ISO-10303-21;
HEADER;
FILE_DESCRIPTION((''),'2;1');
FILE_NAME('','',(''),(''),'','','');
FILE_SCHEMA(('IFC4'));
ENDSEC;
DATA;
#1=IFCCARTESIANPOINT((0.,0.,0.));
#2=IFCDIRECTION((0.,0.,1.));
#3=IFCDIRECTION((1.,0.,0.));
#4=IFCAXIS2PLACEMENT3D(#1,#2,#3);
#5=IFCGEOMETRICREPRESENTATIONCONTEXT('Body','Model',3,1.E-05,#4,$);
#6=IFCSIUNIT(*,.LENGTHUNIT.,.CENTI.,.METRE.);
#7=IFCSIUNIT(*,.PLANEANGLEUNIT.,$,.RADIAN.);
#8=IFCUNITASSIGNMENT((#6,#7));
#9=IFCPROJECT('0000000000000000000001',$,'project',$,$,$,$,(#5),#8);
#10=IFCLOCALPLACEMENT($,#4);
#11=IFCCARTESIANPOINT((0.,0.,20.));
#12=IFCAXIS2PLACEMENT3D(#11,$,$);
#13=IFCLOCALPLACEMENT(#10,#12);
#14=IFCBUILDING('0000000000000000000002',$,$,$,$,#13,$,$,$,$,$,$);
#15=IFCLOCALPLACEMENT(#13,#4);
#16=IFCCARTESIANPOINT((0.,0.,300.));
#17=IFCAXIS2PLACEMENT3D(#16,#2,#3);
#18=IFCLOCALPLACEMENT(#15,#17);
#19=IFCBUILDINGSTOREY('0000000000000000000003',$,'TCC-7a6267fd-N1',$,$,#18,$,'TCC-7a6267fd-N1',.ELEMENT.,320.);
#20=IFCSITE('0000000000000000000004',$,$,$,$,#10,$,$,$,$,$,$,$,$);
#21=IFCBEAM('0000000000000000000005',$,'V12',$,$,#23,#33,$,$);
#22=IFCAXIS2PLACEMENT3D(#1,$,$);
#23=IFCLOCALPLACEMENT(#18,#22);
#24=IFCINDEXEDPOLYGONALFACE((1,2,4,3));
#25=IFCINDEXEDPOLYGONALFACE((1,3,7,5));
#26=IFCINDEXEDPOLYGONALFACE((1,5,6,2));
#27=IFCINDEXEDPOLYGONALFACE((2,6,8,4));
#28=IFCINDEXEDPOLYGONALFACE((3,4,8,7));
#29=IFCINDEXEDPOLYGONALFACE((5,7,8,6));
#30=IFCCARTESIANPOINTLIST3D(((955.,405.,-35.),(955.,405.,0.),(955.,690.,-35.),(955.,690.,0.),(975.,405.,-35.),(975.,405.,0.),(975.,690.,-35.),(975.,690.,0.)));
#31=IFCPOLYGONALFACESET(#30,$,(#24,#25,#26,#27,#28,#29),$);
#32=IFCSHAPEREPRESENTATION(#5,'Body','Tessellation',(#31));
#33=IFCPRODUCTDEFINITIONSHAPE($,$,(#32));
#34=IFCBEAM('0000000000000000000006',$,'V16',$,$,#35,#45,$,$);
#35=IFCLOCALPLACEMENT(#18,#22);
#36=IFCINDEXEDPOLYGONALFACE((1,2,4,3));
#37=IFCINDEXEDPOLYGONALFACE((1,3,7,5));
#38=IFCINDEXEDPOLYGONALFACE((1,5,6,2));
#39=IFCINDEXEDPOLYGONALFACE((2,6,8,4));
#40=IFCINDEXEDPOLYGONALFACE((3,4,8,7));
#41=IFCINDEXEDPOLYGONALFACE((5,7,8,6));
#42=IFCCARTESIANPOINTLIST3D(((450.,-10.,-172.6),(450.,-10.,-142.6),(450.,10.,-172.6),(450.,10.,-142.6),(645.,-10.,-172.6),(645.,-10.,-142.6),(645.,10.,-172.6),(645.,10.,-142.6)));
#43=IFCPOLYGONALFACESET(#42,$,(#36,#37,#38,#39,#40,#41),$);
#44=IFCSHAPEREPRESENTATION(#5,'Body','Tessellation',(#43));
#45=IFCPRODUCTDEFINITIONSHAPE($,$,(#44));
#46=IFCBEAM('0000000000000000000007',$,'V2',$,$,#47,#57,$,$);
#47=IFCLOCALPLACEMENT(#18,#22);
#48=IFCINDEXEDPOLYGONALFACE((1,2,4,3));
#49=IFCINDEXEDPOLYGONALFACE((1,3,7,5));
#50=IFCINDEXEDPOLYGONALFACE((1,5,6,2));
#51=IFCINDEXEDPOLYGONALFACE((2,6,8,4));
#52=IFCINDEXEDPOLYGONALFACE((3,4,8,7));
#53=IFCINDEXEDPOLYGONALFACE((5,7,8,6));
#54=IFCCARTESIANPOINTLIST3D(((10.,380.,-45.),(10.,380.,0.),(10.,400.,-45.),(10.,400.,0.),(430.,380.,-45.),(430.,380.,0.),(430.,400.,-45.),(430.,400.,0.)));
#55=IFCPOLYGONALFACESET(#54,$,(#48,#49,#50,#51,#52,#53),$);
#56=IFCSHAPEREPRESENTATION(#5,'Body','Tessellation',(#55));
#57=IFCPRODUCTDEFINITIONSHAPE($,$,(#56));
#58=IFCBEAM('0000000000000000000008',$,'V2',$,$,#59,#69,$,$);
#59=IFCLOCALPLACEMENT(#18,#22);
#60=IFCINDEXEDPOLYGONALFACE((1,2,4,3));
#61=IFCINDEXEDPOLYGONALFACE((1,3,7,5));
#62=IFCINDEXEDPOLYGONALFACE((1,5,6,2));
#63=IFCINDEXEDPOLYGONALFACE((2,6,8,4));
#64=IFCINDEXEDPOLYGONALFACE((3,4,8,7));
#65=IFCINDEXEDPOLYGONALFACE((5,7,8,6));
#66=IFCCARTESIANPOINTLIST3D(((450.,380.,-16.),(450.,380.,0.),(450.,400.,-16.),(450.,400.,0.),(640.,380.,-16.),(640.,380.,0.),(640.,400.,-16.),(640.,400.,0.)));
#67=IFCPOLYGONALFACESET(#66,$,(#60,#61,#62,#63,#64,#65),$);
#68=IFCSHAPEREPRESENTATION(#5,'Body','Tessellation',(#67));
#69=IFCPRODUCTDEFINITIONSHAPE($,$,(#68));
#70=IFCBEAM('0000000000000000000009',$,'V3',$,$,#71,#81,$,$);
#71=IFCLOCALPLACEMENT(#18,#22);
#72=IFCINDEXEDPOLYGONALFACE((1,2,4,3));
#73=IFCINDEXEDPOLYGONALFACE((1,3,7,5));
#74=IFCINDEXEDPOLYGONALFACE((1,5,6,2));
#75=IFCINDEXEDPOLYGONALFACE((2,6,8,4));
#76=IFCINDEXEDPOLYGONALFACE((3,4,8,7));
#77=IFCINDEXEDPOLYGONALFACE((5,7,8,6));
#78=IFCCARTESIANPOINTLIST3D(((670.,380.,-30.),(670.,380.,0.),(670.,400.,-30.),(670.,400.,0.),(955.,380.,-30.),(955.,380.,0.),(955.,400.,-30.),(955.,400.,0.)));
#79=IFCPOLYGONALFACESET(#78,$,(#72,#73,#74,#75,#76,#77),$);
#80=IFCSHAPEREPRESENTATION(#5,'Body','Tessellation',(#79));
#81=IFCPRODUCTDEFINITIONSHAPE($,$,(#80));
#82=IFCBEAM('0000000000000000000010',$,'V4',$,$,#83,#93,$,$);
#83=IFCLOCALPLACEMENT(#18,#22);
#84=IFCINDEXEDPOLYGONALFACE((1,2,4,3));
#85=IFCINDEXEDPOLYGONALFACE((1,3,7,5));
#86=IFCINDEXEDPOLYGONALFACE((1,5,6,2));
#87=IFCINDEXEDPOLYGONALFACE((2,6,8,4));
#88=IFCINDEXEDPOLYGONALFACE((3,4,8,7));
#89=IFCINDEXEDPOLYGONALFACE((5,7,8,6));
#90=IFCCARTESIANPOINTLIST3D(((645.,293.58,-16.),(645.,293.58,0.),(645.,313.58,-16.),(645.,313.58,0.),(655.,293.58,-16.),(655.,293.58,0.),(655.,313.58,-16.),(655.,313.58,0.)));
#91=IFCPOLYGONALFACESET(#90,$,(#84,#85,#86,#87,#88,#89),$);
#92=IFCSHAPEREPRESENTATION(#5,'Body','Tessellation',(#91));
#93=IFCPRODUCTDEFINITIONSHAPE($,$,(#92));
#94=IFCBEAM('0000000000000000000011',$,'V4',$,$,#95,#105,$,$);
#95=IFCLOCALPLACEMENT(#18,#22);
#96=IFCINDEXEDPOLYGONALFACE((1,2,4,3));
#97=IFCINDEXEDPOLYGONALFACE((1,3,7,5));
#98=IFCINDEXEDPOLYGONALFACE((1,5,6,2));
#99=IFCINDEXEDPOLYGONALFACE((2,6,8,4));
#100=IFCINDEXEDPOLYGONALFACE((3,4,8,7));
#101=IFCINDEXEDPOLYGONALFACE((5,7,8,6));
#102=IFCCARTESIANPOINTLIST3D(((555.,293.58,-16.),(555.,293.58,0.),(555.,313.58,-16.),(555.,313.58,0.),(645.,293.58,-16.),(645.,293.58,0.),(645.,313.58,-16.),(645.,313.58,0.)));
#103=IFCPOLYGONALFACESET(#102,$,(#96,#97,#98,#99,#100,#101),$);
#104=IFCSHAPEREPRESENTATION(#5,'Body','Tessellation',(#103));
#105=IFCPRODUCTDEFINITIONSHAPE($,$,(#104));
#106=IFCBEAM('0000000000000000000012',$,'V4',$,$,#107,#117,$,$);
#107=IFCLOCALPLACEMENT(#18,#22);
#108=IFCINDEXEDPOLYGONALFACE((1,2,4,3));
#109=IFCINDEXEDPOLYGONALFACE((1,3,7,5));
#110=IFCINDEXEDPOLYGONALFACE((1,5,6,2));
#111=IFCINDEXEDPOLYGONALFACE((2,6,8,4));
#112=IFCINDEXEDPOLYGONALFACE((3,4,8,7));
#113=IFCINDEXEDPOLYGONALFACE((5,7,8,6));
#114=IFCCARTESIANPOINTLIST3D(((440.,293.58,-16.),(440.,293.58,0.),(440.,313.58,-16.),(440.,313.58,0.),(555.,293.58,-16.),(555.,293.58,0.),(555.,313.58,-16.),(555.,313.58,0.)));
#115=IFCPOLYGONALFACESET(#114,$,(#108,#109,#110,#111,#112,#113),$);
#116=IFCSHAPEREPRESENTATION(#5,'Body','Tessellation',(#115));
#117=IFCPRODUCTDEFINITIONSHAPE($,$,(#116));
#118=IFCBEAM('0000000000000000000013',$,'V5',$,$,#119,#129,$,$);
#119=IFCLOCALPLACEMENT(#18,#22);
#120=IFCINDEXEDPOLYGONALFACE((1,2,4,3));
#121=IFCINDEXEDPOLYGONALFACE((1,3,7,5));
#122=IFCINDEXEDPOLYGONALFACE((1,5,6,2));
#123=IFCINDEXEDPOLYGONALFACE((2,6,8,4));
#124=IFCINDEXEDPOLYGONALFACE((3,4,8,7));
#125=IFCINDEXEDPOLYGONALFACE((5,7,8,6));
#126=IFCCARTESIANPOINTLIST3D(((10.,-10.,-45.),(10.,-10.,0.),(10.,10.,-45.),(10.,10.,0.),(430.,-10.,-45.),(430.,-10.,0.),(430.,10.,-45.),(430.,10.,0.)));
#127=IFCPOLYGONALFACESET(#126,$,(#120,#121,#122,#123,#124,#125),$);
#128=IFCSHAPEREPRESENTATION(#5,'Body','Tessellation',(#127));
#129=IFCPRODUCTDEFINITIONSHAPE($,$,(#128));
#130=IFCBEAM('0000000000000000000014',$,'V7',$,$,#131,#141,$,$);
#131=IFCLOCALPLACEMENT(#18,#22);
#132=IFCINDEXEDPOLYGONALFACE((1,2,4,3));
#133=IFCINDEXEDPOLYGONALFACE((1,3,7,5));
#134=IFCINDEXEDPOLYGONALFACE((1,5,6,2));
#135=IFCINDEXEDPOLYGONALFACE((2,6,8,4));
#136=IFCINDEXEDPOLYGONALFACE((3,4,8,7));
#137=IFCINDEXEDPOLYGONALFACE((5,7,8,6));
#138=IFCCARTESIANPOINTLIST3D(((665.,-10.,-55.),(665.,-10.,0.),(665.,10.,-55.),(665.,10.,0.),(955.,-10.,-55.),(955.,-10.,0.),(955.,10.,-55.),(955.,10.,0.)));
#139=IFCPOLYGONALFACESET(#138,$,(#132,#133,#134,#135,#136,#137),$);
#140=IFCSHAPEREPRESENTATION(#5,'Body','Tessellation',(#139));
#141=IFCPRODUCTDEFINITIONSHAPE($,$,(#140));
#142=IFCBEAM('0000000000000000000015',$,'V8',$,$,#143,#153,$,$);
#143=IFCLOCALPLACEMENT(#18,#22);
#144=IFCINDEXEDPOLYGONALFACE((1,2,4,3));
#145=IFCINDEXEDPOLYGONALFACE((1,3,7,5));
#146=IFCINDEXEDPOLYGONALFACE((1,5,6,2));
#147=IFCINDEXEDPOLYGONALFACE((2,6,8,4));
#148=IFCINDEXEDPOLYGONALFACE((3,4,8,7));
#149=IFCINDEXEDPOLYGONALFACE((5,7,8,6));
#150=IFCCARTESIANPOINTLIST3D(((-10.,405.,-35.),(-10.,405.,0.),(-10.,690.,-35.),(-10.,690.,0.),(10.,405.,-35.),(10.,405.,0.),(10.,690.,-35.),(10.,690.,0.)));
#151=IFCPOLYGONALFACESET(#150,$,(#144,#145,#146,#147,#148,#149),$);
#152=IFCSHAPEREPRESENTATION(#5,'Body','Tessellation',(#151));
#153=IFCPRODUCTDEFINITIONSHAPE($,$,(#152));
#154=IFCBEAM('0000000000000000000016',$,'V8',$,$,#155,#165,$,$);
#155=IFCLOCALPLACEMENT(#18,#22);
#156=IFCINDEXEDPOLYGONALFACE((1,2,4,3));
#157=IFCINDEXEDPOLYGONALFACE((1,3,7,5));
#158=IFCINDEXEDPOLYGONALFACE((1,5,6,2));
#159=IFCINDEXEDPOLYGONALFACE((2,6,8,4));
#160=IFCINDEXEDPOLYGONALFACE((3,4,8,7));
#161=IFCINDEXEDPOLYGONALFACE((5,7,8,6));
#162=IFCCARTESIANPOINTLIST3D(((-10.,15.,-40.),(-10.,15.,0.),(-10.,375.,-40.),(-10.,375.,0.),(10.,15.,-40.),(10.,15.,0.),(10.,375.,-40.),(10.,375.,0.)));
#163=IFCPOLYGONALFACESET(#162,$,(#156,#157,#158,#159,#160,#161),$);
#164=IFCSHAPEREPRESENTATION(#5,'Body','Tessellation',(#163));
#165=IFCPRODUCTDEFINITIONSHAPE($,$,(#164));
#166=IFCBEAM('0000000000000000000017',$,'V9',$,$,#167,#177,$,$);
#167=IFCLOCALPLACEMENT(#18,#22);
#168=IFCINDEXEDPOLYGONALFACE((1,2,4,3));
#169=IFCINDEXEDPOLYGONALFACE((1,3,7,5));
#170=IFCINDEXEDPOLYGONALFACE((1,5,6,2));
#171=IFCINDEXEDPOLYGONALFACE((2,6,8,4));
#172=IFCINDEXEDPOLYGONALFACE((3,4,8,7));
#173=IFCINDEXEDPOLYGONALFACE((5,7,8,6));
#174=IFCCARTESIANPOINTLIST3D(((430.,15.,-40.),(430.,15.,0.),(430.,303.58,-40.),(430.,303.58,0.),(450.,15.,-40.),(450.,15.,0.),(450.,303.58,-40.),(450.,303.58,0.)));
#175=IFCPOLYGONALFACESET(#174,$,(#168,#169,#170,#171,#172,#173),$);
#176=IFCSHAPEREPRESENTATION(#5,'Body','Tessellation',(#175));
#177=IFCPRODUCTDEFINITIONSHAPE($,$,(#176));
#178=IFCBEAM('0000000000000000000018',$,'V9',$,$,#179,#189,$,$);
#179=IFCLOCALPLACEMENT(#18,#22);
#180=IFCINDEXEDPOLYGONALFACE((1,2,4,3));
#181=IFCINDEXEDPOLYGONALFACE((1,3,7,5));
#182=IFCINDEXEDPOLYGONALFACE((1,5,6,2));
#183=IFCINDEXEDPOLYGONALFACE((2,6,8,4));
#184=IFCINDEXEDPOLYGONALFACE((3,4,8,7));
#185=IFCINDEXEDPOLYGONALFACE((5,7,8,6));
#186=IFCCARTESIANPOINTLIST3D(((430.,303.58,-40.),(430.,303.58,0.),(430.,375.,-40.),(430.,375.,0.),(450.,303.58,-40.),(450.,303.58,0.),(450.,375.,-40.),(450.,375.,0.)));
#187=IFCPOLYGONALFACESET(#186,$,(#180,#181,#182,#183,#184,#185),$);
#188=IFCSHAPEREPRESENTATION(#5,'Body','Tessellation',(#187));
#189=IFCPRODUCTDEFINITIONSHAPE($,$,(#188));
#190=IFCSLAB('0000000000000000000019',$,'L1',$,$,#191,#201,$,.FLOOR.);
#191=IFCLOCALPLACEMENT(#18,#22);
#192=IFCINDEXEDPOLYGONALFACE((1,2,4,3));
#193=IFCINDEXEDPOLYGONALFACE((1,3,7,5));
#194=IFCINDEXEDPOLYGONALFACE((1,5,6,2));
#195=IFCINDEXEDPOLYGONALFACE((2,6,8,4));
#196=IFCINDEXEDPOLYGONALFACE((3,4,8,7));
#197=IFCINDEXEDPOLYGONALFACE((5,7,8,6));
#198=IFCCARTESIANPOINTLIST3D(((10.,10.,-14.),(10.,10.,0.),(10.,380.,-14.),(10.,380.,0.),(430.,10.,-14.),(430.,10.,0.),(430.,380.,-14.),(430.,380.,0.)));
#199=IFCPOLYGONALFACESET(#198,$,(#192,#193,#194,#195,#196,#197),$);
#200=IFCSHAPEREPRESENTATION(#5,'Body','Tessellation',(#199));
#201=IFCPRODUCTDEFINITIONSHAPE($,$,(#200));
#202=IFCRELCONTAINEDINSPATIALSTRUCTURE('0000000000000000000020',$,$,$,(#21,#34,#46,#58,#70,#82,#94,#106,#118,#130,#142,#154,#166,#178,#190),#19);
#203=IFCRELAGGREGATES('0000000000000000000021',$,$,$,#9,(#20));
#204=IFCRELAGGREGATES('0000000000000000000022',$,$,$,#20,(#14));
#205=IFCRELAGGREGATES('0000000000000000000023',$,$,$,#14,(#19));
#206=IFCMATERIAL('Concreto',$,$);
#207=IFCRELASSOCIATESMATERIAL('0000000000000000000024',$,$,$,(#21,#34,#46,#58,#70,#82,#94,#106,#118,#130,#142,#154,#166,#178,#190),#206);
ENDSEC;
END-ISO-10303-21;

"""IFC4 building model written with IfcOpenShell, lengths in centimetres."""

from ifc_helpers import new_model, si_unit, frame, origin_with_axes, origin_2d_with_axis, place, context, project, spatial, polyline, rectangle, outline, extrude, material, element, save


model = new_model("IFC4")

# Units and contexts
model_context = context("Model", 3, precision=1e-05, world=origin_with_axes(), identifier="Body")
ifc_project = project(units=[si_unit("LENGTHUNIT", "METRE", prefix="CENTI"), si_unit("PLANEANGLEUNIT", "RADIAN")], contexts=[model_context])

# Site, building, storey
site_placement = place(None, origin_with_axes())
site = spatial("IfcSite", under=ifc_project, at=site_placement)
building_placement = place(site_placement, frame((0.0, 0.0, 20.0)))
building = spatial("IfcBuilding", under=site, at=building_placement)
placement = place(building_placement, origin_with_axes())
storey_placement = place(placement, frame((0.0, 0.0, 300.0), z_axis=(0.0, 0.0, 1.0), x_axis=(1.0, 0.0, 0.0)))
storey = spatial("IfcBuildingStorey", under=building, at=storey_placement, Name="TCC-7a6267fd-N1", LongName="TCC-7a6267fd-N1", CompositionType="ELEMENT", Elevation=320.0)

# Shared definitions
ifc_material = material(Name="Concreto")

# Beams
beam_1_placement = place(storey_placement, frame((965.0, 547.5, 0.0), z_axis=(0.0, 0.0, 1.0), x_axis=(1.0, 0.0, 0.0)))
element("IfcBeam", 1, at=beam_1_placement, inside=storey, material=ifc_material, Name="V12", context=model_context, shape_type="SolidModel", body=[
    extrude(rectangle(XDim=20.0, YDim=35.0, at=origin_2d_with_axis()), frame((0.0, -142.5, -17.5), z_axis=(0.0, 1.0, 0.0), x_axis=(1.0, 0.0, 0.0)), (0.0, 0.0, 1.0), 285.0),
])
beam_2_placement = place(storey_placement, frame((547.5, 0.0, -142.6), z_axis=(0.0, 0.0, 1.0), x_axis=(1.0, 0.0, 0.0)))
element("IfcBeam", 2, at=beam_2_placement, inside=storey, material=ifc_material, Name="V16", context=model_context, shape_type="SolidModel", body=[
    extrude(rectangle(XDim=20.0, YDim=30.0, at=origin_2d_with_axis()), frame((-97.5, 0.0, -15.0), z_axis=(1.0, 0.0, 0.0), x_axis=(0.0, 1.0, 0.0)), (0.0, 0.0, 1.0), 195.0),
])
beam_3_placement = place(storey_placement, frame((220.0, 390.0, 0.0), z_axis=(0.0, 0.0, 1.0), x_axis=(1.0, 0.0, 0.0)))
element("IfcBeam", 3, at=beam_3_placement, inside=storey, material=ifc_material, Name="V2", context=model_context, shape_type="SolidModel", body=[
    extrude(rectangle(XDim=20.0, YDim=45.0, at=origin_2d_with_axis()), frame((210.0, 0.0, -22.5), z_axis=(-1.0, 0.0, 0.0), x_axis=(0.0, 1.0, 0.0)), (0.0, 0.0, 1.0), 420.0),
])
beam_4_placement = place(storey_placement, frame((545.0, 390.0, 0.0), z_axis=(0.0, 0.0, 1.0), x_axis=(1.0, 0.0, 0.0)))
element("IfcBeam", 4, at=beam_4_placement, inside=storey, material=ifc_material, Name="V2", context=model_context, shape_type="SolidModel", body=[
    extrude(rectangle(XDim=20.0, YDim=16.0, at=origin_2d_with_axis()), frame((95.0, 0.0, -8.0), z_axis=(-1.0, 0.0, 0.0), x_axis=(0.0, 1.0, 0.0)), (0.0, 0.0, 1.0), 190.0),
])
beam_5_placement = place(storey_placement, frame((812.5, 390.0, 0.0), z_axis=(0.0, 0.0, 1.0), x_axis=(1.0, 0.0, 0.0)))
element("IfcBeam", 5, at=beam_5_placement, inside=storey, material=ifc_material, Name="V3", context=model_context, shape_type="SolidModel", body=[
    extrude(rectangle(XDim=20.0, YDim=30.0, at=origin_2d_with_axis()), frame((-142.5, 0.0, -15.0), z_axis=(1.0, 0.0, 0.0), x_axis=(0.0, 1.0, 0.0)), (0.0, 0.0, 1.0), 285.0),
])
beam_6_placement = place(storey_placement, frame((650.0, 303.58, 0.0), z_axis=(0.0, 0.0, 1.0), x_axis=(1.0, 0.0, 0.0)))
element("IfcBeam", 6, at=beam_6_placement, inside=storey, material=ifc_material, Name="V4", context=model_context, shape_type="SolidModel", body=[
    extrude(rectangle(XDim=20.0, YDim=16.0, at=origin_2d_with_axis()), frame((-5.0, 0.0, -8.0), z_axis=(1.0, 0.0, 0.0), x_axis=(0.0, 1.0, 0.0)), (0.0, 0.0, 1.0), 10.0),
])
beam_7_placement = place(storey_placement, frame((600.0, 303.58, 0.0), z_axis=(0.0, 0.0, 1.0), x_axis=(1.0, 0.0, 0.0)))
element("IfcBeam", 7, at=beam_7_placement, inside=storey, material=ifc_material, Name="V4", context=model_context, shape_type="SolidModel", body=[
    extrude(rectangle(XDim=20.0, YDim=16.0, at=origin_2d_with_axis()), frame((-45.0, 0.0, -8.0), z_axis=(1.0, 0.0, 0.0), x_axis=(0.0, 1.0, 0.0)), (0.0, 0.0, 1.0), 90.0),
])
beam_8_placement = place(storey_placement, frame((497.5, 303.58, 0.0), z_axis=(0.0, 0.0, 1.0), x_axis=(1.0, 0.0, 0.0)))
element("IfcBeam", 8, at=beam_8_placement, inside=storey, material=ifc_material, Name="V4", context=model_context, shape_type="SolidModel", body=[
    extrude(rectangle(XDim=20.0, YDim=16.0, at=origin_2d_with_axis()), frame((-57.5, 0.0, -8.0), z_axis=(1.0, 0.0, 0.0), x_axis=(0.0, 1.0, 0.0)), (0.0, 0.0, 1.0), 115.0),
])
beam_9_placement = place(storey_placement, frame((220.0, 0.0, 0.0), z_axis=(0.0, 0.0, 1.0), x_axis=(1.0, 0.0, 0.0)))
element("IfcBeam", 9, at=beam_9_placement, inside=storey, material=ifc_material, Name="V5", context=model_context, shape_type="SolidModel", body=[
    extrude(rectangle(XDim=20.0, YDim=45.0, at=origin_2d_with_axis()), frame((-210.0, 0.0, -22.5), z_axis=(1.0, 0.0, 0.0), x_axis=(0.0, 1.0, 0.0)), (0.0, 0.0, 1.0), 420.0),
])
beam_10_placement = place(storey_placement, frame((810.0, 0.0, 0.0), z_axis=(0.0, 0.0, 1.0), x_axis=(1.0, 0.0, 0.0)))
element("IfcBeam", 10, at=beam_10_placement, inside=storey, material=ifc_material, Name="V7", context=model_context, shape_type="SolidModel", body=[
    extrude(rectangle(XDim=20.0, YDim=55.0, at=origin_2d_with_axis()), frame((-145.0, 0.0, -27.5), z_axis=(1.0, 0.0, 0.0), x_axis=(0.0, 1.0, 0.0)), (0.0, 0.0, 1.0), 290.0),
])
beam_11_placement = place(storey_placement, frame((0.0, 547.5, 0.0), z_axis=(0.0, 0.0, 1.0), x_axis=(1.0, 0.0, 0.0)))
element("IfcBeam", 11, at=beam_11_placement, inside=storey, material=ifc_material, Name="V8", context=model_context, shape_type="SolidModel", body=[
    extrude(rectangle(XDim=20.0, YDim=35.0, at=origin_2d_with_axis()), frame((0.0, 142.5, -17.5), z_axis=(0.0, -1.0, 0.0), x_axis=(-1.0, 0.0, 0.0)), (0.0, 0.0, 1.0), 285.0),
])
beam_12_placement = place(storey_placement, frame((0.0, 195.0, 0.0), z_axis=(0.0, 0.0, 1.0), x_axis=(1.0, 0.0, 0.0)))
element("IfcBeam", 12, at=beam_12_placement, inside=storey, material=ifc_material, Name="V8", context=model_context, shape_type="SolidModel", body=[
    extrude(rectangle(XDim=20.0, YDim=40.0, at=origin_2d_with_axis()), frame((0.0, 180.0, -20.0), z_axis=(0.0, -1.0, 0.0), x_axis=(-1.0, 0.0, 0.0)), (0.0, 0.0, 1.0), 360.0),
])
beam_13_placement = place(storey_placement, frame((440.0, 159.29, 0.0), z_axis=(0.0, 0.0, 1.0), x_axis=(1.0, 0.0, 0.0)))
element("IfcBeam", 13, at=beam_13_placement, inside=storey, material=ifc_material, Name="V9", context=model_context, shape_type="SolidModel", body=[
    extrude(rectangle(XDim=20.0, YDim=40.0, at=origin_2d_with_axis()), frame((0.0, -144.29, -20.0), z_axis=(0.0, 1.0, 0.0), x_axis=(1.0, 0.0, 0.0)), (0.0, 0.0, 1.0), 288.58),
])
beam_14_placement = place(storey_placement, frame((440.0, 339.29, 0.0), z_axis=(0.0, 0.0, 1.0), x_axis=(1.0, 0.0, 0.0)))
element("IfcBeam", 14, at=beam_14_placement, inside=storey, material=ifc_material, Name="V9", context=model_context, shape_type="SolidModel", body=[
    extrude(rectangle(XDim=20.0, YDim=40.0, at=origin_2d_with_axis()), frame((0.0, -35.71, -20.0), z_axis=(0.0, 1.0, 0.0), x_axis=(1.0, 0.0, 0.0)), (0.0, 0.0, 1.0), 71.42),
])

# Slab
slab_1_placement = place(storey_placement, frame((220.0, 195.0, 0.0), z_axis=(0.0, 0.0, 1.0), x_axis=(1.0, 0.0, 0.0)))
element("IfcSlab", 15, at=slab_1_placement, inside=storey, material=ifc_material, Name="L1", PredefinedType="FLOOR", context=model_context, shape_type="SolidModel", body=[
    extrude(outline(polyline([(210.0, 185.0), (-210.0, 185.0), (-210.0, -185.0), (210.0, -185.0), (210.0, 185.0), (210.0, 185.0)])), frame((0.0, 0.0, -14.0), z_axis=(0.0, 0.0, 1.0), x_axis=(1.0, 0.0, 0.0)), (0.0, 0.0, 1.0), 14.0),
])

save(model, "model.ifc")
